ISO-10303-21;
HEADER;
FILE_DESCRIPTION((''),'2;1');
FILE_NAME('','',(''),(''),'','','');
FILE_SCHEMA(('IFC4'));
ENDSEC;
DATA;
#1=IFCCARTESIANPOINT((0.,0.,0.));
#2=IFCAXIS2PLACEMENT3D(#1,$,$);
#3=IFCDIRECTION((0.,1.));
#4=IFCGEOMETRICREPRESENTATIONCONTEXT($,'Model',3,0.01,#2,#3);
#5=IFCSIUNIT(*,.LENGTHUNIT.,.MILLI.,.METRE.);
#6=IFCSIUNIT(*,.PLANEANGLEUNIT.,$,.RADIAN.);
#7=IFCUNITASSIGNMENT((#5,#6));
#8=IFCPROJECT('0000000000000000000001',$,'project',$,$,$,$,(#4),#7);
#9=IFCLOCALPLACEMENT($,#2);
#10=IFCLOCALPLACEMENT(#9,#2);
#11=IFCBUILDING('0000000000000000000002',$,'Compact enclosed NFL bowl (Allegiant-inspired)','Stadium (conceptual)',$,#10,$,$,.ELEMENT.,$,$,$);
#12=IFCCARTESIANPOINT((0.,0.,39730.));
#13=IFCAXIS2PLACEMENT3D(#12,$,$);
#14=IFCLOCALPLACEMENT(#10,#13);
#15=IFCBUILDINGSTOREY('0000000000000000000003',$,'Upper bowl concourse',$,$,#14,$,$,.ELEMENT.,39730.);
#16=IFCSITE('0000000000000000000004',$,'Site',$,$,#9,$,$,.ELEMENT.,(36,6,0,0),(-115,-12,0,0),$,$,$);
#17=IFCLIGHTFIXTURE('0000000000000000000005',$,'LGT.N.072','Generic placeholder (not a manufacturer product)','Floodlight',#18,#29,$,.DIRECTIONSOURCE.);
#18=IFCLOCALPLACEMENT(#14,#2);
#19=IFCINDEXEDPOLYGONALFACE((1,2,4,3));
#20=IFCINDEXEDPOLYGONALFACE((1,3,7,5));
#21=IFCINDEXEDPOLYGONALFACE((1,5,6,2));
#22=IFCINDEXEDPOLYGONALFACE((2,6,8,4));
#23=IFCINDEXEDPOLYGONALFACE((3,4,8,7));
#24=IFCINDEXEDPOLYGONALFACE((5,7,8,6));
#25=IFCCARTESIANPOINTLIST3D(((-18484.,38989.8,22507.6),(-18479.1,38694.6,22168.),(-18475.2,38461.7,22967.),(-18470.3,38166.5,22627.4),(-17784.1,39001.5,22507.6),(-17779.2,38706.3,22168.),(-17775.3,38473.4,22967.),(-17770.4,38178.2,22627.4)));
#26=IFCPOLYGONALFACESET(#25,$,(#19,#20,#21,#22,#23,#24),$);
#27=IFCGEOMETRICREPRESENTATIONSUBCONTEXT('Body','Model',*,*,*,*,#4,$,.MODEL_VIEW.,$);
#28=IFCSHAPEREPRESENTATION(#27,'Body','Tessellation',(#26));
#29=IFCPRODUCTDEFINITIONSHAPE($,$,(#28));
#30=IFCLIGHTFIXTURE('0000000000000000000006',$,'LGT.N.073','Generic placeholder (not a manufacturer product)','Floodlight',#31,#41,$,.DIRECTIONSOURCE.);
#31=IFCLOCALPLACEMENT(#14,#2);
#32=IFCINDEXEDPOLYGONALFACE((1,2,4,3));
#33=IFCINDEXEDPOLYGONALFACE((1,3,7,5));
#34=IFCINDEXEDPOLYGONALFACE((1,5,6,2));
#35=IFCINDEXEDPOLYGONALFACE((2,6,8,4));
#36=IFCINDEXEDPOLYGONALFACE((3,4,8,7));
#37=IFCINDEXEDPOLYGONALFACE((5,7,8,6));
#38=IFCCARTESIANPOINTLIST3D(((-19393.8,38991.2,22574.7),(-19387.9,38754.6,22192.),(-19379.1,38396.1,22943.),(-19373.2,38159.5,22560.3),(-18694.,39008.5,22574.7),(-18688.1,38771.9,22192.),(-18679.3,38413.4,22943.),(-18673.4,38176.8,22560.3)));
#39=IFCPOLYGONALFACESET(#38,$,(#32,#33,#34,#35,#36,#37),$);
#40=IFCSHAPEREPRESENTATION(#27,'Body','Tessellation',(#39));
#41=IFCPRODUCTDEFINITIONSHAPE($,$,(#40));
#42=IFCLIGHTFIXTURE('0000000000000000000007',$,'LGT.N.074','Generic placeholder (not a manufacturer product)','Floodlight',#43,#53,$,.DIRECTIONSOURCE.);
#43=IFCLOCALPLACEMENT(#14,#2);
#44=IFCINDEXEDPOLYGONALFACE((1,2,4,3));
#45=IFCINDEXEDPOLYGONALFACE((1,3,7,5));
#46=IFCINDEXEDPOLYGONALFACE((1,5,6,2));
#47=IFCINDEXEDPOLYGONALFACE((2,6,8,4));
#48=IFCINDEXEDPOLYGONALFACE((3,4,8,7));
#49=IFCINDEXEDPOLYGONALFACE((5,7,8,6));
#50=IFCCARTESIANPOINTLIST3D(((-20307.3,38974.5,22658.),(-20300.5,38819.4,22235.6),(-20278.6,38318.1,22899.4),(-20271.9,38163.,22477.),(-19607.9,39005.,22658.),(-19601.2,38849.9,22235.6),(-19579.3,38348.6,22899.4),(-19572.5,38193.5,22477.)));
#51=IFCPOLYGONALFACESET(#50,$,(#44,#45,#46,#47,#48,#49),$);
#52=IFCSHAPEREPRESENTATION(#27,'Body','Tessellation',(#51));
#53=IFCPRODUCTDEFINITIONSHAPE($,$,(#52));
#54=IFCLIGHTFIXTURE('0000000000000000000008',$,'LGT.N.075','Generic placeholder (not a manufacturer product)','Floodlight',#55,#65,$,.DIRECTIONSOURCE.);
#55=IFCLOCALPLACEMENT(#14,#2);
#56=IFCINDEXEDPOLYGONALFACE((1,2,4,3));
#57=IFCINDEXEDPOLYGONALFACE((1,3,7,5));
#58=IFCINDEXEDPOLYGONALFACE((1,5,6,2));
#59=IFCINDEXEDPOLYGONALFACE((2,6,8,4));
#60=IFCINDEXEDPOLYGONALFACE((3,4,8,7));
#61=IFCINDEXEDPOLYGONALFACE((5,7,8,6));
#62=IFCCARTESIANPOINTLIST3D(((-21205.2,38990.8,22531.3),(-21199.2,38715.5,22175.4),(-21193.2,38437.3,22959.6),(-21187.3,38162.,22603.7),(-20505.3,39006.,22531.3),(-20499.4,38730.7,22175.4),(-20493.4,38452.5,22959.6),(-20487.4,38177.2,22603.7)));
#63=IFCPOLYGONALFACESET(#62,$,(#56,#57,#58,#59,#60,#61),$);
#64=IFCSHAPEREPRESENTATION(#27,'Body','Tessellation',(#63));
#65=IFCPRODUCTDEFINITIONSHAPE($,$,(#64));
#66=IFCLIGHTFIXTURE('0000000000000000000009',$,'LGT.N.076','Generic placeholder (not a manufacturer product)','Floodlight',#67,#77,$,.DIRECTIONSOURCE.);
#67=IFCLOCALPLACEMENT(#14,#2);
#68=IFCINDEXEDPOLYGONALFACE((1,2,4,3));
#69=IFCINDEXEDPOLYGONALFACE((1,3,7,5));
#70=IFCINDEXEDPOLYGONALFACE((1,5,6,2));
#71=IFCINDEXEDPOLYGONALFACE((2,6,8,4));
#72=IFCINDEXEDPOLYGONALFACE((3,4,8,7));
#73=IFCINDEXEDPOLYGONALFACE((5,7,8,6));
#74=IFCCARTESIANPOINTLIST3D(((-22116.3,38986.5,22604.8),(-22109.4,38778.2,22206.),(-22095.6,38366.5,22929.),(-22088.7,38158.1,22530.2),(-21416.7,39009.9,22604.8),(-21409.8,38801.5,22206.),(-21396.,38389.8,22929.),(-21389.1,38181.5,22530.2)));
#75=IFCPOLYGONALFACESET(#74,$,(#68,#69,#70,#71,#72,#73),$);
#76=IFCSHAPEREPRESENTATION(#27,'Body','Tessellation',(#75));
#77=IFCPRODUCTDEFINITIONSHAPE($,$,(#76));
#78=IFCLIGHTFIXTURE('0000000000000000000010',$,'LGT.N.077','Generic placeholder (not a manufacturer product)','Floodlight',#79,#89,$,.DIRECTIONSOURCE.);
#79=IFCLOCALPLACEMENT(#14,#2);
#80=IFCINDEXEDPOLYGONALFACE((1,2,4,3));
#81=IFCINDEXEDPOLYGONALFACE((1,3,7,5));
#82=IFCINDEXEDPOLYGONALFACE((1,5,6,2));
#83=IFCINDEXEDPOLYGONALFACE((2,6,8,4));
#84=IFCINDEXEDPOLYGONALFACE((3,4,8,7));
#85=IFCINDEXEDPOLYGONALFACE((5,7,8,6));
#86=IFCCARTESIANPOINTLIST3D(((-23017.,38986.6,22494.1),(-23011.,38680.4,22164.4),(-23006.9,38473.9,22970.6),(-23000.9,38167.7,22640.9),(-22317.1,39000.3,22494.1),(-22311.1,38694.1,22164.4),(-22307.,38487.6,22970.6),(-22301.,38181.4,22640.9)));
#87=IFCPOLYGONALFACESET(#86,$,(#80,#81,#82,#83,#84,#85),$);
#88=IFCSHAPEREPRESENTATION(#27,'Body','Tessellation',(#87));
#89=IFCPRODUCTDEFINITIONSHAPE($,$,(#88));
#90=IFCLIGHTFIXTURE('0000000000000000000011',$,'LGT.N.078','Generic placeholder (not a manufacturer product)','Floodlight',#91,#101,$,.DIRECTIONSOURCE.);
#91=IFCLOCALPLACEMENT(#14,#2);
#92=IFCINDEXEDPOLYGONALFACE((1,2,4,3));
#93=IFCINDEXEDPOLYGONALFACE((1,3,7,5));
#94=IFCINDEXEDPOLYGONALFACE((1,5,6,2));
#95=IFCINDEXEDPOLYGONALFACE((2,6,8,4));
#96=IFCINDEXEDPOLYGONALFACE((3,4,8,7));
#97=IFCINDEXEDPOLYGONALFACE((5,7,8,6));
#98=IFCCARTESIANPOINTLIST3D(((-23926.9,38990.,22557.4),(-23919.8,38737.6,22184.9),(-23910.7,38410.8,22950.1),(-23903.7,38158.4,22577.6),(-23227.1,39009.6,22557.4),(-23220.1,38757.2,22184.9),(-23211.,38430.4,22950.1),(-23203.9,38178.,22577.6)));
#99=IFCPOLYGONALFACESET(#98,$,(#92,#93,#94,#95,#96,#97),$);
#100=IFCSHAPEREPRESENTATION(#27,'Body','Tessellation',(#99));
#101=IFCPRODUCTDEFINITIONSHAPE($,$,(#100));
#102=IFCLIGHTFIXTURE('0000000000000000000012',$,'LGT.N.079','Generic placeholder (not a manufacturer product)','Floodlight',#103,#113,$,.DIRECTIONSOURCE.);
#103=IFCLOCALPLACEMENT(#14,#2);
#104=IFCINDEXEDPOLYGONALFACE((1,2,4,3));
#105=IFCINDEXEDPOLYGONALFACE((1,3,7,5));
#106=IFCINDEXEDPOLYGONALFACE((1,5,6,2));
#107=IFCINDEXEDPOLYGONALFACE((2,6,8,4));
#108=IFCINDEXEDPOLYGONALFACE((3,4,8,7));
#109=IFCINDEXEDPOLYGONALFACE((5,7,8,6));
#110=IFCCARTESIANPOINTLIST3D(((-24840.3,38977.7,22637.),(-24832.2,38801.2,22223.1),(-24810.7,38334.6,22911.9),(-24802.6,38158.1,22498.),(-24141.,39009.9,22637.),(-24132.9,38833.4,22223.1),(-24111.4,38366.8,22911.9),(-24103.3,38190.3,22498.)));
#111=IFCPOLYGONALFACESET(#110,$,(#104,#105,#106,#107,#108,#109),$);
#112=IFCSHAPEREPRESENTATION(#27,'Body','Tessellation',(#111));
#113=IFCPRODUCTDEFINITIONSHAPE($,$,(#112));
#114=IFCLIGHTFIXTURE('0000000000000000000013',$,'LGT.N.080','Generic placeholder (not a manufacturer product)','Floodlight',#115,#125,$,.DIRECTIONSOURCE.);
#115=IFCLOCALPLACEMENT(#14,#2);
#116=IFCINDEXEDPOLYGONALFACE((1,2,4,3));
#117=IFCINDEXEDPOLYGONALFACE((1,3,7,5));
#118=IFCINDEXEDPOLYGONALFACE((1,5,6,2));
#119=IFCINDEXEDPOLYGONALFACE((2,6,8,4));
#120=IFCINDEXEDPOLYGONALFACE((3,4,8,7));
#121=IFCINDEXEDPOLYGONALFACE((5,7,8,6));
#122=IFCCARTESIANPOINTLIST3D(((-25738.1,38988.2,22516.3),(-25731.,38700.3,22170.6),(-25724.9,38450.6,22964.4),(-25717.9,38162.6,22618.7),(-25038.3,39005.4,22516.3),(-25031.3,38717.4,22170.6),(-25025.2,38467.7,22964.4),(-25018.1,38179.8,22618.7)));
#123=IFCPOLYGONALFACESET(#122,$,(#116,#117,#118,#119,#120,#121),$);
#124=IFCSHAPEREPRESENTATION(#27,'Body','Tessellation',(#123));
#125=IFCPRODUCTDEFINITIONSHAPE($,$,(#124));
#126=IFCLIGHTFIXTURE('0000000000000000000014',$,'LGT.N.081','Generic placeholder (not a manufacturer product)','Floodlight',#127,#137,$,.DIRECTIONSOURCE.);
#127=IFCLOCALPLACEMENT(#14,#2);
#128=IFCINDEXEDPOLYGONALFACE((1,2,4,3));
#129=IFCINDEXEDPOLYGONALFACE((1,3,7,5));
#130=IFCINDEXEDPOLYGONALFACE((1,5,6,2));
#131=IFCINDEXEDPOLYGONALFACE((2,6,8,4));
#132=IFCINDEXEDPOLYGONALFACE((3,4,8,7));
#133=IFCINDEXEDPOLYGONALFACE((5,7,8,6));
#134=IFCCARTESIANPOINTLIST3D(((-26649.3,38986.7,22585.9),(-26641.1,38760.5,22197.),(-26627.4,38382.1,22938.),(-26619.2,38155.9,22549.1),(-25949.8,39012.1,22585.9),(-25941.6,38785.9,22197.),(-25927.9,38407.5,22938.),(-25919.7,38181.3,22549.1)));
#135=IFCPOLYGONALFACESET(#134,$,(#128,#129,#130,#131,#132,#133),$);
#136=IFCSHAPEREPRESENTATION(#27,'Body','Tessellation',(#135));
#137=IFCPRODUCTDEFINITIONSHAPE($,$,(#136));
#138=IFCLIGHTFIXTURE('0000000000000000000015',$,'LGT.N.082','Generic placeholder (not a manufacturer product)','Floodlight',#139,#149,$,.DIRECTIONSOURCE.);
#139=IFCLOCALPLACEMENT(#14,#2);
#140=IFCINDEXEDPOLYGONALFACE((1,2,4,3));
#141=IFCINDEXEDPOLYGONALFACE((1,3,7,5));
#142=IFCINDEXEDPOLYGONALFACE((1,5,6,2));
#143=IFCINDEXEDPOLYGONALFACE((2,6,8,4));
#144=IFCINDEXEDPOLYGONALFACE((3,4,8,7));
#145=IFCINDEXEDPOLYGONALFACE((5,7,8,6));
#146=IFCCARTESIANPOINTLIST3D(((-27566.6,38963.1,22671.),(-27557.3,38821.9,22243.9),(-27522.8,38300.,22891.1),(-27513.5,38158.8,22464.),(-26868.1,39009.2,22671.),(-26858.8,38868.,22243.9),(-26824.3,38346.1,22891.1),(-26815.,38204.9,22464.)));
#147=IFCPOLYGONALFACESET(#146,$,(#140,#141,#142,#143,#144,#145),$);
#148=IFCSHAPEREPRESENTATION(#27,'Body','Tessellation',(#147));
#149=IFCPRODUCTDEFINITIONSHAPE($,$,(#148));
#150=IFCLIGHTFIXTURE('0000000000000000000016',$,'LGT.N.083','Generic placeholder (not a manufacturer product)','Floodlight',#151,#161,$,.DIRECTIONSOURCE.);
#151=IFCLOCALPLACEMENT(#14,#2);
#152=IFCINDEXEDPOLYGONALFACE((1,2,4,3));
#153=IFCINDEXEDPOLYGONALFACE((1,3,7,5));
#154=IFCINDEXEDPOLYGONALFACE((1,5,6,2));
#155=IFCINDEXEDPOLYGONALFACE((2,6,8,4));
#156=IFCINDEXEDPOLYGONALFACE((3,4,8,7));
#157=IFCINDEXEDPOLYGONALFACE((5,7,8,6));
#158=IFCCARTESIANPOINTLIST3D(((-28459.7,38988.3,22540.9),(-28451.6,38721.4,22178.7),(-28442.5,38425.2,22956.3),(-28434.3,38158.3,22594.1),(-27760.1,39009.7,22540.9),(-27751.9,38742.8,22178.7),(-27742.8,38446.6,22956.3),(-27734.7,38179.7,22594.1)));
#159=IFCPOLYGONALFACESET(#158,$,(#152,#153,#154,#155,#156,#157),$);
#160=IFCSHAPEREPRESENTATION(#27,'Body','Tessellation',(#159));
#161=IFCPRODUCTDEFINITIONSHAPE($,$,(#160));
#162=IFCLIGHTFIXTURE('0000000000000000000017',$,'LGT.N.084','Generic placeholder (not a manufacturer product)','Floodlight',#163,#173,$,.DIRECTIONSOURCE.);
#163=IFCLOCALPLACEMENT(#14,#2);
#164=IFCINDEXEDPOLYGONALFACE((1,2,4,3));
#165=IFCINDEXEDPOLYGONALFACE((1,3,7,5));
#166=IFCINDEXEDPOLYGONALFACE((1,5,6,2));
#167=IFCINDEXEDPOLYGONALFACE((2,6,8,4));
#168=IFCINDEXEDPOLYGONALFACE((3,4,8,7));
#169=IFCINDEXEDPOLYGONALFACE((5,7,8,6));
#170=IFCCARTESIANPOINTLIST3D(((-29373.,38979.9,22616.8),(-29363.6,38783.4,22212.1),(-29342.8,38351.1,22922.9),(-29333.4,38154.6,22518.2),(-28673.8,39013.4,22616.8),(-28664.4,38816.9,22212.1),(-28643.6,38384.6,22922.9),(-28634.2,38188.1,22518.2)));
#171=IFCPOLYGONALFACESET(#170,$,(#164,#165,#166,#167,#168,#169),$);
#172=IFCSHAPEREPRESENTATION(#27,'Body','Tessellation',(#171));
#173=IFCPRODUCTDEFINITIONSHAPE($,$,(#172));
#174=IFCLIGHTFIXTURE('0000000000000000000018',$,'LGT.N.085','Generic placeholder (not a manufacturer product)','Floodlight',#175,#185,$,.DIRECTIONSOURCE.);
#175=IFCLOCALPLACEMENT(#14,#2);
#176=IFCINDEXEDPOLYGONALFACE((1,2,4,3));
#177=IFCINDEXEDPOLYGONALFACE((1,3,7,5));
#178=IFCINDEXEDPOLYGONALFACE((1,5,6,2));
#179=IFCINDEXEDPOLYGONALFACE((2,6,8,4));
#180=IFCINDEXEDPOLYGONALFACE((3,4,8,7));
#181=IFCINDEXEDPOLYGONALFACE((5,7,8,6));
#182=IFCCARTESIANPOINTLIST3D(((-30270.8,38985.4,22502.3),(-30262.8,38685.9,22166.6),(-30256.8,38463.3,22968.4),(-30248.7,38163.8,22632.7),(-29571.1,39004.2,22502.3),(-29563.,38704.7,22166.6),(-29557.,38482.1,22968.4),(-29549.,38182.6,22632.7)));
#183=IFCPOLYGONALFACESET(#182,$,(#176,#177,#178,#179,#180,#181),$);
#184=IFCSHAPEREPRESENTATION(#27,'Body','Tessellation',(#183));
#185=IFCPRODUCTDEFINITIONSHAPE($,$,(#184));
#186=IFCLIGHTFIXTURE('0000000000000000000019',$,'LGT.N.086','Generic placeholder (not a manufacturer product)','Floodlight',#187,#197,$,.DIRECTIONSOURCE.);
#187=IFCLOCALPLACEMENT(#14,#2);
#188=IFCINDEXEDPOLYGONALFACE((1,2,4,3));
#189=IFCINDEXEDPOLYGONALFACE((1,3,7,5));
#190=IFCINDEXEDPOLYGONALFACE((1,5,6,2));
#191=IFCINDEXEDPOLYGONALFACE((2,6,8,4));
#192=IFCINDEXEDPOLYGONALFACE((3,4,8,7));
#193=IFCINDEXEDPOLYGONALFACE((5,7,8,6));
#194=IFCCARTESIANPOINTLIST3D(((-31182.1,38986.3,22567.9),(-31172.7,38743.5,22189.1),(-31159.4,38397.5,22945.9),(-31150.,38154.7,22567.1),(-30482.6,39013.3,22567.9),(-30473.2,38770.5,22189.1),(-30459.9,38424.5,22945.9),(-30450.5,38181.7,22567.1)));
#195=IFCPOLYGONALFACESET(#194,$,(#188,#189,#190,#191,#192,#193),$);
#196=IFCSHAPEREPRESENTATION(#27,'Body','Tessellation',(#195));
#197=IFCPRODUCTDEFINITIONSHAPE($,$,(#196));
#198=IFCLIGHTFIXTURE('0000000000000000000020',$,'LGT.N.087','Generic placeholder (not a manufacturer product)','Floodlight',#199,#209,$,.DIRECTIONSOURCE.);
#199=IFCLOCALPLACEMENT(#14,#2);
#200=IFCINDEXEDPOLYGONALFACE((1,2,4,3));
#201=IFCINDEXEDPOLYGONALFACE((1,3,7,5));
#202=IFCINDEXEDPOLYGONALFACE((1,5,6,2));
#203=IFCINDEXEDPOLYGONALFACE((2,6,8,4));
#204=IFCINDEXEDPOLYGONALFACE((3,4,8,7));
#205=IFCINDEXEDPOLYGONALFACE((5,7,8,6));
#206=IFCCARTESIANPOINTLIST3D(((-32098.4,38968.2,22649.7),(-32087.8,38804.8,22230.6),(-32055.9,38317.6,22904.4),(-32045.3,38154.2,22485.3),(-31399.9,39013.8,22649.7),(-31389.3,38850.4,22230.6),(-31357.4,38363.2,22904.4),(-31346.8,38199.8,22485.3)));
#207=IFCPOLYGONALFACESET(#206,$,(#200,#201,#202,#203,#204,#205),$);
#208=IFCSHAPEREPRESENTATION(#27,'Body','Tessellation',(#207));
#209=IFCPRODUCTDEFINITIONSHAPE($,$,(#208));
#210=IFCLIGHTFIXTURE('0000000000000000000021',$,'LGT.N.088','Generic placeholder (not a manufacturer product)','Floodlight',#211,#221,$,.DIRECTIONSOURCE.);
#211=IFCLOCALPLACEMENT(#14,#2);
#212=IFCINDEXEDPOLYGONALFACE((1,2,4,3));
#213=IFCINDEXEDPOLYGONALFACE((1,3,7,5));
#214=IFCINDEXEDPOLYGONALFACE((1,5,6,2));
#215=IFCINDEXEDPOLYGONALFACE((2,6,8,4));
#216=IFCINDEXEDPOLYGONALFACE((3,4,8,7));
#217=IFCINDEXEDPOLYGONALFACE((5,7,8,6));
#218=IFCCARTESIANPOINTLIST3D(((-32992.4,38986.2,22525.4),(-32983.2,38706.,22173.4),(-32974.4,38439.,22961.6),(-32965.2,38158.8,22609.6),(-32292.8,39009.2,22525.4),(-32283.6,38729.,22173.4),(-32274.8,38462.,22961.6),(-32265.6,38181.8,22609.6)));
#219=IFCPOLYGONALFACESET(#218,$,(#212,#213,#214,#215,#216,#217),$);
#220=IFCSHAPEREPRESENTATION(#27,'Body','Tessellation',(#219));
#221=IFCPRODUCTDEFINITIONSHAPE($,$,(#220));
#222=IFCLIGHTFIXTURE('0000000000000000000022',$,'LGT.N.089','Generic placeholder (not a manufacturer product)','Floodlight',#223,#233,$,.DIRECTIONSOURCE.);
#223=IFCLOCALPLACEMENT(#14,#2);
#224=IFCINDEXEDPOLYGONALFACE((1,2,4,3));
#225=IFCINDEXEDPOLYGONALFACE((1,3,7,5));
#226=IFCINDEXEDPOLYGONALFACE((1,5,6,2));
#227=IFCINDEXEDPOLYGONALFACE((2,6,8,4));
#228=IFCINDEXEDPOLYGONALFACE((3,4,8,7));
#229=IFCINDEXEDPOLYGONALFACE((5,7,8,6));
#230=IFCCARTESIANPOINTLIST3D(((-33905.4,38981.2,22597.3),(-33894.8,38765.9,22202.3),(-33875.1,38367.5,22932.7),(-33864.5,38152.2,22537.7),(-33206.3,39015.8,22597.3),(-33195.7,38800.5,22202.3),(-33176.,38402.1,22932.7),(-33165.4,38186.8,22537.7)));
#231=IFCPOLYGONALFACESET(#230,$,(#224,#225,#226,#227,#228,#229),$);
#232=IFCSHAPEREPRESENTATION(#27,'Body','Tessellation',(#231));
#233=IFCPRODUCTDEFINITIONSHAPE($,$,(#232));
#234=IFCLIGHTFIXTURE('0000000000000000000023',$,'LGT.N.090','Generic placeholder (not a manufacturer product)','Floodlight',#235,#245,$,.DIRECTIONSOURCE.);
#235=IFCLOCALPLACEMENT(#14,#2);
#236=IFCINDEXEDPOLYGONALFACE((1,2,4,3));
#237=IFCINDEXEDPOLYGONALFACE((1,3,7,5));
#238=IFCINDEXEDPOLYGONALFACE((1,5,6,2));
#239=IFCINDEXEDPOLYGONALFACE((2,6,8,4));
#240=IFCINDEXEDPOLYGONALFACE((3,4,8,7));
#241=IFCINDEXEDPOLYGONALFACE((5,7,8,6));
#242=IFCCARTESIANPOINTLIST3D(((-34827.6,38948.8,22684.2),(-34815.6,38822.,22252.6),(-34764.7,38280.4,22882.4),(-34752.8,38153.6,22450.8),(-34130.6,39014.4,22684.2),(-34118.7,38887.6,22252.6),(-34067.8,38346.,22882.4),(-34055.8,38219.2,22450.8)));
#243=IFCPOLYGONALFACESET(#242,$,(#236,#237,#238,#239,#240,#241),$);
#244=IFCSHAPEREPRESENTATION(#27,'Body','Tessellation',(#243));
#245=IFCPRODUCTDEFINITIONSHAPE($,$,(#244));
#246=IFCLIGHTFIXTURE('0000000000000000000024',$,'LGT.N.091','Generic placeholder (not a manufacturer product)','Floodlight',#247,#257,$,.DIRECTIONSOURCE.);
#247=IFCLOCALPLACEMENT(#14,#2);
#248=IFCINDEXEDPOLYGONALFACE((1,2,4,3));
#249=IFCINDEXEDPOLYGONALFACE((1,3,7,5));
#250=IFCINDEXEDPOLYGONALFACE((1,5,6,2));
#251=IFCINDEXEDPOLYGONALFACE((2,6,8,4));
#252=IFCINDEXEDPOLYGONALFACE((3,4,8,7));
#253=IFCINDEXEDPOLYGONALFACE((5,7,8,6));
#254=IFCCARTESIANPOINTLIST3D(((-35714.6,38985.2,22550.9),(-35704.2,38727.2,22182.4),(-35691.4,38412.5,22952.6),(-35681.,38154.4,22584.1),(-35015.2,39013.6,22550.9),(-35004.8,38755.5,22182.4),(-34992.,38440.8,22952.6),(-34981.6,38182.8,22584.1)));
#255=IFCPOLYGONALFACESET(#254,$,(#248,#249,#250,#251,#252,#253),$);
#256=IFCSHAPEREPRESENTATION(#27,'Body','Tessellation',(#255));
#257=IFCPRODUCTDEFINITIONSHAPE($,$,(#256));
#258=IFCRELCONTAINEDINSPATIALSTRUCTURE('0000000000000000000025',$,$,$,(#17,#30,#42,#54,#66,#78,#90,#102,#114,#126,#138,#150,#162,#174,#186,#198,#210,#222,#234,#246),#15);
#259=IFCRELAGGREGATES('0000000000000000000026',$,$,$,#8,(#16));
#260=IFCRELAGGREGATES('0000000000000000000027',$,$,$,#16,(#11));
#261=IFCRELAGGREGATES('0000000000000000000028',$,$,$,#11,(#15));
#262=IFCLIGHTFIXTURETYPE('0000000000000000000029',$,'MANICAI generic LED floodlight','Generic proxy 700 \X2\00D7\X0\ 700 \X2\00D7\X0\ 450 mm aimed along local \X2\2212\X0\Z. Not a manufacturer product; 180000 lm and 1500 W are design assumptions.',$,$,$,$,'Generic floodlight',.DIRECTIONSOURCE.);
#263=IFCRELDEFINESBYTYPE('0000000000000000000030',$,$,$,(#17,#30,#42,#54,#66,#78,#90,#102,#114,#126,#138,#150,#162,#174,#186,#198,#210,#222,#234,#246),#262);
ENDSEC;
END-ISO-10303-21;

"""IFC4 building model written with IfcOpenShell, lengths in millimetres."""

from ifc_helpers import new_model, si_unit, direction, frame, origin, place, context, subcontext, project, spatial, rectangle, extrude, source, transform, mapped, type_object, type_shapes, element, save


model = new_model("IFC4")

# Units and contexts
model_context = context("Model", 3, precision=0.01, world=origin(), true_north=direction((0.0, 1.0)))
body_context = subcontext(model_context, "Body", "Model", "MODEL_VIEW")
ifc_project = project(units=[si_unit("LENGTHUNIT", "METRE", prefix="MILLI"), si_unit("PLANEANGLEUNIT", "RADIAN")], contexts=[model_context])

# Site, building, storey
site_placement = place(None, origin())
site = spatial("IfcSite", under=ifc_project, at=site_placement, Name="Site", CompositionType="ELEMENT", RefLatitude=(36, 6, 0, 0), RefLongitude=(-115, -12, 0, 0))
building_placement = place(site_placement, origin())
building = spatial("IfcBuilding", under=site, at=building_placement, Name="Compact enclosed NFL bowl (Allegiant-inspired)", Description="Stadium (conceptual)", CompositionType="ELEMENT")
storey_placement = place(building_placement, frame((0.0, 0.0, 39730.0)))
storey = spatial("IfcBuildingStorey", under=building, at=storey_placement, Name="Upper bowl concourse", CompositionType="ELEMENT", Elevation=39730.0)

# Light fixtures
light_fixture_type = type_object("IfcLightFixtureType", Name="MANICAI generic LED floodlight", Description="Generic proxy 700 × 700 × 450 mm aimed along local −Z. Not a manufacturer product; 180000 lm and 1500 W are design assumptions.", ElementType="Generic floodlight", PredefinedType="DIRECTIONSOURCE")
shared_shape = source(origin(), body_context, "Body", "SweptSolid", [
    extrude(rectangle(XDim=700.0, YDim=700.0), frame((0.0, 0.0, -225.0)), (0.0, 0.0, 1.0), 450.0),
])
type_shapes(light_fixture_type, [shared_shape])
for number, where, z_axis, x_axis, name in (
    (1, (-18127.2, 38584.0, 22567.5), (-0.010978, 0.656111, 0.754584), (-0.99986, -0.01673, 0.0), "LGT.N.072"),
    (2, (-19033.6, 38584.0, 22567.5), (-0.012992, 0.525869, 0.850466), (-0.999695, -0.024698, 0.0), "LGT.N.073"),
    (3, (-19939.9, 38584.0, 22567.5), (-0.015022, 0.344623, 0.938621), (-0.999051, -0.043547, 0.0), "LGT.N.074"),
    (4, (-20846.3, 38584.0, 22567.5), (-0.013233, 0.611807, 0.790896), (-0.999766, -0.021624, 0.0), "LGT.N.075"),
    (5, (-21752.7, 38584.0, 22567.5), (-0.015473, 0.462965, 0.886242), (-0.999442, -0.033402, 0.0), "LGT.N.076"),
    (6, (-22659.0, 38584.0, 22567.5), (-0.013324, 0.680478, 0.732647), (-0.999808, -0.019577, 0.0), "LGT.N.077"),
    (7, (-23565.4, 38584.0, 22567.5), (-0.015656, 0.560895, 0.827739), (-0.999611, -0.027901, 0.0), "LGT.N.078"),
    (8, (-24471.8, 38584.0, 22567.5), (-0.018064, 0.392208, 0.919699), (-0.998941, -0.046008, 0.0), "LGT.N.079"),
    (9, (-25378.1, 38584.0, 22567.5), (-0.015649, 0.639889, 0.768308), (-0.999701, -0.024449, 0.0), "LGT.N.080"),
    (10, (-26284.5, 38584.0, 22567.5), (-0.018232, 0.502724, 0.864255), (-0.999343, -0.036243, 0.0), "LGT.N.081"),
    (11, (-27190.8, 38584.0, 22567.5), (-0.020716, 0.31375, 0.94928), (-0.997827, -0.065885, 0.0), "LGT.N.082"),
    (12, (-28097.2, 38584.0, 22567.5), (-0.018151, 0.59314, 0.804895), (-0.999532, -0.030587, 0.0), "LGT.N.083"),
    (13, (-29003.6, 38584.0, 22567.5), (-0.020934, 0.436831, 0.8993), (-0.998854, -0.047868, 0.0), "LGT.N.084"),
    (14, (-29909.9, 38584.0, 22567.5), (-0.01791, 0.665615, 0.746081), (-0.999638, -0.026898, 0.0), "LGT.N.085"),
    (15, (-30816.3, 38584.0, 22567.5), (-0.020818, 0.539521, 0.841715), (-0.999256, -0.038558, 0.0), "LGT.N.086"),
    (16, (-31722.6, 38584.0, 22567.5), (-0.023715, 0.363087, 0.931453), (-0.997874, -0.065177, 0.0), "LGT.N.087"),
    (17, (-32629.0, 38584.0, 22567.5), (-0.020483, 0.622755, 0.782149), (-0.99946, -0.032873, 0.0), "LGT.N.088"),
    (18, (-33535.4, 38584.0, 22567.5), (-0.023627, 0.478437, 0.877804), (-0.998783, -0.049323, 0.0), "LGT.N.089"),
    (19, (-34441.7, 38584.0, 22567.5), (-0.026512, 0.281848, 0.959093), (-0.995605, -0.093652, 0.0), "LGT.N.090"),
    (20, (-35348.1, 38584.0, 22567.5), (-0.023233, 0.573457, 0.818906), (-0.99918, -0.04048, 0.0), "LGT.N.091"),
):
    element("IfcLightFixture", number, at=place(storey_placement, frame(where, z_axis=z_axis, x_axis=x_axis)), inside=storey, type_object=light_fixture_type, Name=name, Description="Generic placeholder (not a manufacturer product)", ObjectType="Floodlight", PredefinedType="DIRECTIONSOURCE", context=body_context, shape_type="MappedRepresentation", body=[
        mapped(shared_shape, transform((0.0, 0.0, 0.0))),
    ])

save(model, "model.ifc")
